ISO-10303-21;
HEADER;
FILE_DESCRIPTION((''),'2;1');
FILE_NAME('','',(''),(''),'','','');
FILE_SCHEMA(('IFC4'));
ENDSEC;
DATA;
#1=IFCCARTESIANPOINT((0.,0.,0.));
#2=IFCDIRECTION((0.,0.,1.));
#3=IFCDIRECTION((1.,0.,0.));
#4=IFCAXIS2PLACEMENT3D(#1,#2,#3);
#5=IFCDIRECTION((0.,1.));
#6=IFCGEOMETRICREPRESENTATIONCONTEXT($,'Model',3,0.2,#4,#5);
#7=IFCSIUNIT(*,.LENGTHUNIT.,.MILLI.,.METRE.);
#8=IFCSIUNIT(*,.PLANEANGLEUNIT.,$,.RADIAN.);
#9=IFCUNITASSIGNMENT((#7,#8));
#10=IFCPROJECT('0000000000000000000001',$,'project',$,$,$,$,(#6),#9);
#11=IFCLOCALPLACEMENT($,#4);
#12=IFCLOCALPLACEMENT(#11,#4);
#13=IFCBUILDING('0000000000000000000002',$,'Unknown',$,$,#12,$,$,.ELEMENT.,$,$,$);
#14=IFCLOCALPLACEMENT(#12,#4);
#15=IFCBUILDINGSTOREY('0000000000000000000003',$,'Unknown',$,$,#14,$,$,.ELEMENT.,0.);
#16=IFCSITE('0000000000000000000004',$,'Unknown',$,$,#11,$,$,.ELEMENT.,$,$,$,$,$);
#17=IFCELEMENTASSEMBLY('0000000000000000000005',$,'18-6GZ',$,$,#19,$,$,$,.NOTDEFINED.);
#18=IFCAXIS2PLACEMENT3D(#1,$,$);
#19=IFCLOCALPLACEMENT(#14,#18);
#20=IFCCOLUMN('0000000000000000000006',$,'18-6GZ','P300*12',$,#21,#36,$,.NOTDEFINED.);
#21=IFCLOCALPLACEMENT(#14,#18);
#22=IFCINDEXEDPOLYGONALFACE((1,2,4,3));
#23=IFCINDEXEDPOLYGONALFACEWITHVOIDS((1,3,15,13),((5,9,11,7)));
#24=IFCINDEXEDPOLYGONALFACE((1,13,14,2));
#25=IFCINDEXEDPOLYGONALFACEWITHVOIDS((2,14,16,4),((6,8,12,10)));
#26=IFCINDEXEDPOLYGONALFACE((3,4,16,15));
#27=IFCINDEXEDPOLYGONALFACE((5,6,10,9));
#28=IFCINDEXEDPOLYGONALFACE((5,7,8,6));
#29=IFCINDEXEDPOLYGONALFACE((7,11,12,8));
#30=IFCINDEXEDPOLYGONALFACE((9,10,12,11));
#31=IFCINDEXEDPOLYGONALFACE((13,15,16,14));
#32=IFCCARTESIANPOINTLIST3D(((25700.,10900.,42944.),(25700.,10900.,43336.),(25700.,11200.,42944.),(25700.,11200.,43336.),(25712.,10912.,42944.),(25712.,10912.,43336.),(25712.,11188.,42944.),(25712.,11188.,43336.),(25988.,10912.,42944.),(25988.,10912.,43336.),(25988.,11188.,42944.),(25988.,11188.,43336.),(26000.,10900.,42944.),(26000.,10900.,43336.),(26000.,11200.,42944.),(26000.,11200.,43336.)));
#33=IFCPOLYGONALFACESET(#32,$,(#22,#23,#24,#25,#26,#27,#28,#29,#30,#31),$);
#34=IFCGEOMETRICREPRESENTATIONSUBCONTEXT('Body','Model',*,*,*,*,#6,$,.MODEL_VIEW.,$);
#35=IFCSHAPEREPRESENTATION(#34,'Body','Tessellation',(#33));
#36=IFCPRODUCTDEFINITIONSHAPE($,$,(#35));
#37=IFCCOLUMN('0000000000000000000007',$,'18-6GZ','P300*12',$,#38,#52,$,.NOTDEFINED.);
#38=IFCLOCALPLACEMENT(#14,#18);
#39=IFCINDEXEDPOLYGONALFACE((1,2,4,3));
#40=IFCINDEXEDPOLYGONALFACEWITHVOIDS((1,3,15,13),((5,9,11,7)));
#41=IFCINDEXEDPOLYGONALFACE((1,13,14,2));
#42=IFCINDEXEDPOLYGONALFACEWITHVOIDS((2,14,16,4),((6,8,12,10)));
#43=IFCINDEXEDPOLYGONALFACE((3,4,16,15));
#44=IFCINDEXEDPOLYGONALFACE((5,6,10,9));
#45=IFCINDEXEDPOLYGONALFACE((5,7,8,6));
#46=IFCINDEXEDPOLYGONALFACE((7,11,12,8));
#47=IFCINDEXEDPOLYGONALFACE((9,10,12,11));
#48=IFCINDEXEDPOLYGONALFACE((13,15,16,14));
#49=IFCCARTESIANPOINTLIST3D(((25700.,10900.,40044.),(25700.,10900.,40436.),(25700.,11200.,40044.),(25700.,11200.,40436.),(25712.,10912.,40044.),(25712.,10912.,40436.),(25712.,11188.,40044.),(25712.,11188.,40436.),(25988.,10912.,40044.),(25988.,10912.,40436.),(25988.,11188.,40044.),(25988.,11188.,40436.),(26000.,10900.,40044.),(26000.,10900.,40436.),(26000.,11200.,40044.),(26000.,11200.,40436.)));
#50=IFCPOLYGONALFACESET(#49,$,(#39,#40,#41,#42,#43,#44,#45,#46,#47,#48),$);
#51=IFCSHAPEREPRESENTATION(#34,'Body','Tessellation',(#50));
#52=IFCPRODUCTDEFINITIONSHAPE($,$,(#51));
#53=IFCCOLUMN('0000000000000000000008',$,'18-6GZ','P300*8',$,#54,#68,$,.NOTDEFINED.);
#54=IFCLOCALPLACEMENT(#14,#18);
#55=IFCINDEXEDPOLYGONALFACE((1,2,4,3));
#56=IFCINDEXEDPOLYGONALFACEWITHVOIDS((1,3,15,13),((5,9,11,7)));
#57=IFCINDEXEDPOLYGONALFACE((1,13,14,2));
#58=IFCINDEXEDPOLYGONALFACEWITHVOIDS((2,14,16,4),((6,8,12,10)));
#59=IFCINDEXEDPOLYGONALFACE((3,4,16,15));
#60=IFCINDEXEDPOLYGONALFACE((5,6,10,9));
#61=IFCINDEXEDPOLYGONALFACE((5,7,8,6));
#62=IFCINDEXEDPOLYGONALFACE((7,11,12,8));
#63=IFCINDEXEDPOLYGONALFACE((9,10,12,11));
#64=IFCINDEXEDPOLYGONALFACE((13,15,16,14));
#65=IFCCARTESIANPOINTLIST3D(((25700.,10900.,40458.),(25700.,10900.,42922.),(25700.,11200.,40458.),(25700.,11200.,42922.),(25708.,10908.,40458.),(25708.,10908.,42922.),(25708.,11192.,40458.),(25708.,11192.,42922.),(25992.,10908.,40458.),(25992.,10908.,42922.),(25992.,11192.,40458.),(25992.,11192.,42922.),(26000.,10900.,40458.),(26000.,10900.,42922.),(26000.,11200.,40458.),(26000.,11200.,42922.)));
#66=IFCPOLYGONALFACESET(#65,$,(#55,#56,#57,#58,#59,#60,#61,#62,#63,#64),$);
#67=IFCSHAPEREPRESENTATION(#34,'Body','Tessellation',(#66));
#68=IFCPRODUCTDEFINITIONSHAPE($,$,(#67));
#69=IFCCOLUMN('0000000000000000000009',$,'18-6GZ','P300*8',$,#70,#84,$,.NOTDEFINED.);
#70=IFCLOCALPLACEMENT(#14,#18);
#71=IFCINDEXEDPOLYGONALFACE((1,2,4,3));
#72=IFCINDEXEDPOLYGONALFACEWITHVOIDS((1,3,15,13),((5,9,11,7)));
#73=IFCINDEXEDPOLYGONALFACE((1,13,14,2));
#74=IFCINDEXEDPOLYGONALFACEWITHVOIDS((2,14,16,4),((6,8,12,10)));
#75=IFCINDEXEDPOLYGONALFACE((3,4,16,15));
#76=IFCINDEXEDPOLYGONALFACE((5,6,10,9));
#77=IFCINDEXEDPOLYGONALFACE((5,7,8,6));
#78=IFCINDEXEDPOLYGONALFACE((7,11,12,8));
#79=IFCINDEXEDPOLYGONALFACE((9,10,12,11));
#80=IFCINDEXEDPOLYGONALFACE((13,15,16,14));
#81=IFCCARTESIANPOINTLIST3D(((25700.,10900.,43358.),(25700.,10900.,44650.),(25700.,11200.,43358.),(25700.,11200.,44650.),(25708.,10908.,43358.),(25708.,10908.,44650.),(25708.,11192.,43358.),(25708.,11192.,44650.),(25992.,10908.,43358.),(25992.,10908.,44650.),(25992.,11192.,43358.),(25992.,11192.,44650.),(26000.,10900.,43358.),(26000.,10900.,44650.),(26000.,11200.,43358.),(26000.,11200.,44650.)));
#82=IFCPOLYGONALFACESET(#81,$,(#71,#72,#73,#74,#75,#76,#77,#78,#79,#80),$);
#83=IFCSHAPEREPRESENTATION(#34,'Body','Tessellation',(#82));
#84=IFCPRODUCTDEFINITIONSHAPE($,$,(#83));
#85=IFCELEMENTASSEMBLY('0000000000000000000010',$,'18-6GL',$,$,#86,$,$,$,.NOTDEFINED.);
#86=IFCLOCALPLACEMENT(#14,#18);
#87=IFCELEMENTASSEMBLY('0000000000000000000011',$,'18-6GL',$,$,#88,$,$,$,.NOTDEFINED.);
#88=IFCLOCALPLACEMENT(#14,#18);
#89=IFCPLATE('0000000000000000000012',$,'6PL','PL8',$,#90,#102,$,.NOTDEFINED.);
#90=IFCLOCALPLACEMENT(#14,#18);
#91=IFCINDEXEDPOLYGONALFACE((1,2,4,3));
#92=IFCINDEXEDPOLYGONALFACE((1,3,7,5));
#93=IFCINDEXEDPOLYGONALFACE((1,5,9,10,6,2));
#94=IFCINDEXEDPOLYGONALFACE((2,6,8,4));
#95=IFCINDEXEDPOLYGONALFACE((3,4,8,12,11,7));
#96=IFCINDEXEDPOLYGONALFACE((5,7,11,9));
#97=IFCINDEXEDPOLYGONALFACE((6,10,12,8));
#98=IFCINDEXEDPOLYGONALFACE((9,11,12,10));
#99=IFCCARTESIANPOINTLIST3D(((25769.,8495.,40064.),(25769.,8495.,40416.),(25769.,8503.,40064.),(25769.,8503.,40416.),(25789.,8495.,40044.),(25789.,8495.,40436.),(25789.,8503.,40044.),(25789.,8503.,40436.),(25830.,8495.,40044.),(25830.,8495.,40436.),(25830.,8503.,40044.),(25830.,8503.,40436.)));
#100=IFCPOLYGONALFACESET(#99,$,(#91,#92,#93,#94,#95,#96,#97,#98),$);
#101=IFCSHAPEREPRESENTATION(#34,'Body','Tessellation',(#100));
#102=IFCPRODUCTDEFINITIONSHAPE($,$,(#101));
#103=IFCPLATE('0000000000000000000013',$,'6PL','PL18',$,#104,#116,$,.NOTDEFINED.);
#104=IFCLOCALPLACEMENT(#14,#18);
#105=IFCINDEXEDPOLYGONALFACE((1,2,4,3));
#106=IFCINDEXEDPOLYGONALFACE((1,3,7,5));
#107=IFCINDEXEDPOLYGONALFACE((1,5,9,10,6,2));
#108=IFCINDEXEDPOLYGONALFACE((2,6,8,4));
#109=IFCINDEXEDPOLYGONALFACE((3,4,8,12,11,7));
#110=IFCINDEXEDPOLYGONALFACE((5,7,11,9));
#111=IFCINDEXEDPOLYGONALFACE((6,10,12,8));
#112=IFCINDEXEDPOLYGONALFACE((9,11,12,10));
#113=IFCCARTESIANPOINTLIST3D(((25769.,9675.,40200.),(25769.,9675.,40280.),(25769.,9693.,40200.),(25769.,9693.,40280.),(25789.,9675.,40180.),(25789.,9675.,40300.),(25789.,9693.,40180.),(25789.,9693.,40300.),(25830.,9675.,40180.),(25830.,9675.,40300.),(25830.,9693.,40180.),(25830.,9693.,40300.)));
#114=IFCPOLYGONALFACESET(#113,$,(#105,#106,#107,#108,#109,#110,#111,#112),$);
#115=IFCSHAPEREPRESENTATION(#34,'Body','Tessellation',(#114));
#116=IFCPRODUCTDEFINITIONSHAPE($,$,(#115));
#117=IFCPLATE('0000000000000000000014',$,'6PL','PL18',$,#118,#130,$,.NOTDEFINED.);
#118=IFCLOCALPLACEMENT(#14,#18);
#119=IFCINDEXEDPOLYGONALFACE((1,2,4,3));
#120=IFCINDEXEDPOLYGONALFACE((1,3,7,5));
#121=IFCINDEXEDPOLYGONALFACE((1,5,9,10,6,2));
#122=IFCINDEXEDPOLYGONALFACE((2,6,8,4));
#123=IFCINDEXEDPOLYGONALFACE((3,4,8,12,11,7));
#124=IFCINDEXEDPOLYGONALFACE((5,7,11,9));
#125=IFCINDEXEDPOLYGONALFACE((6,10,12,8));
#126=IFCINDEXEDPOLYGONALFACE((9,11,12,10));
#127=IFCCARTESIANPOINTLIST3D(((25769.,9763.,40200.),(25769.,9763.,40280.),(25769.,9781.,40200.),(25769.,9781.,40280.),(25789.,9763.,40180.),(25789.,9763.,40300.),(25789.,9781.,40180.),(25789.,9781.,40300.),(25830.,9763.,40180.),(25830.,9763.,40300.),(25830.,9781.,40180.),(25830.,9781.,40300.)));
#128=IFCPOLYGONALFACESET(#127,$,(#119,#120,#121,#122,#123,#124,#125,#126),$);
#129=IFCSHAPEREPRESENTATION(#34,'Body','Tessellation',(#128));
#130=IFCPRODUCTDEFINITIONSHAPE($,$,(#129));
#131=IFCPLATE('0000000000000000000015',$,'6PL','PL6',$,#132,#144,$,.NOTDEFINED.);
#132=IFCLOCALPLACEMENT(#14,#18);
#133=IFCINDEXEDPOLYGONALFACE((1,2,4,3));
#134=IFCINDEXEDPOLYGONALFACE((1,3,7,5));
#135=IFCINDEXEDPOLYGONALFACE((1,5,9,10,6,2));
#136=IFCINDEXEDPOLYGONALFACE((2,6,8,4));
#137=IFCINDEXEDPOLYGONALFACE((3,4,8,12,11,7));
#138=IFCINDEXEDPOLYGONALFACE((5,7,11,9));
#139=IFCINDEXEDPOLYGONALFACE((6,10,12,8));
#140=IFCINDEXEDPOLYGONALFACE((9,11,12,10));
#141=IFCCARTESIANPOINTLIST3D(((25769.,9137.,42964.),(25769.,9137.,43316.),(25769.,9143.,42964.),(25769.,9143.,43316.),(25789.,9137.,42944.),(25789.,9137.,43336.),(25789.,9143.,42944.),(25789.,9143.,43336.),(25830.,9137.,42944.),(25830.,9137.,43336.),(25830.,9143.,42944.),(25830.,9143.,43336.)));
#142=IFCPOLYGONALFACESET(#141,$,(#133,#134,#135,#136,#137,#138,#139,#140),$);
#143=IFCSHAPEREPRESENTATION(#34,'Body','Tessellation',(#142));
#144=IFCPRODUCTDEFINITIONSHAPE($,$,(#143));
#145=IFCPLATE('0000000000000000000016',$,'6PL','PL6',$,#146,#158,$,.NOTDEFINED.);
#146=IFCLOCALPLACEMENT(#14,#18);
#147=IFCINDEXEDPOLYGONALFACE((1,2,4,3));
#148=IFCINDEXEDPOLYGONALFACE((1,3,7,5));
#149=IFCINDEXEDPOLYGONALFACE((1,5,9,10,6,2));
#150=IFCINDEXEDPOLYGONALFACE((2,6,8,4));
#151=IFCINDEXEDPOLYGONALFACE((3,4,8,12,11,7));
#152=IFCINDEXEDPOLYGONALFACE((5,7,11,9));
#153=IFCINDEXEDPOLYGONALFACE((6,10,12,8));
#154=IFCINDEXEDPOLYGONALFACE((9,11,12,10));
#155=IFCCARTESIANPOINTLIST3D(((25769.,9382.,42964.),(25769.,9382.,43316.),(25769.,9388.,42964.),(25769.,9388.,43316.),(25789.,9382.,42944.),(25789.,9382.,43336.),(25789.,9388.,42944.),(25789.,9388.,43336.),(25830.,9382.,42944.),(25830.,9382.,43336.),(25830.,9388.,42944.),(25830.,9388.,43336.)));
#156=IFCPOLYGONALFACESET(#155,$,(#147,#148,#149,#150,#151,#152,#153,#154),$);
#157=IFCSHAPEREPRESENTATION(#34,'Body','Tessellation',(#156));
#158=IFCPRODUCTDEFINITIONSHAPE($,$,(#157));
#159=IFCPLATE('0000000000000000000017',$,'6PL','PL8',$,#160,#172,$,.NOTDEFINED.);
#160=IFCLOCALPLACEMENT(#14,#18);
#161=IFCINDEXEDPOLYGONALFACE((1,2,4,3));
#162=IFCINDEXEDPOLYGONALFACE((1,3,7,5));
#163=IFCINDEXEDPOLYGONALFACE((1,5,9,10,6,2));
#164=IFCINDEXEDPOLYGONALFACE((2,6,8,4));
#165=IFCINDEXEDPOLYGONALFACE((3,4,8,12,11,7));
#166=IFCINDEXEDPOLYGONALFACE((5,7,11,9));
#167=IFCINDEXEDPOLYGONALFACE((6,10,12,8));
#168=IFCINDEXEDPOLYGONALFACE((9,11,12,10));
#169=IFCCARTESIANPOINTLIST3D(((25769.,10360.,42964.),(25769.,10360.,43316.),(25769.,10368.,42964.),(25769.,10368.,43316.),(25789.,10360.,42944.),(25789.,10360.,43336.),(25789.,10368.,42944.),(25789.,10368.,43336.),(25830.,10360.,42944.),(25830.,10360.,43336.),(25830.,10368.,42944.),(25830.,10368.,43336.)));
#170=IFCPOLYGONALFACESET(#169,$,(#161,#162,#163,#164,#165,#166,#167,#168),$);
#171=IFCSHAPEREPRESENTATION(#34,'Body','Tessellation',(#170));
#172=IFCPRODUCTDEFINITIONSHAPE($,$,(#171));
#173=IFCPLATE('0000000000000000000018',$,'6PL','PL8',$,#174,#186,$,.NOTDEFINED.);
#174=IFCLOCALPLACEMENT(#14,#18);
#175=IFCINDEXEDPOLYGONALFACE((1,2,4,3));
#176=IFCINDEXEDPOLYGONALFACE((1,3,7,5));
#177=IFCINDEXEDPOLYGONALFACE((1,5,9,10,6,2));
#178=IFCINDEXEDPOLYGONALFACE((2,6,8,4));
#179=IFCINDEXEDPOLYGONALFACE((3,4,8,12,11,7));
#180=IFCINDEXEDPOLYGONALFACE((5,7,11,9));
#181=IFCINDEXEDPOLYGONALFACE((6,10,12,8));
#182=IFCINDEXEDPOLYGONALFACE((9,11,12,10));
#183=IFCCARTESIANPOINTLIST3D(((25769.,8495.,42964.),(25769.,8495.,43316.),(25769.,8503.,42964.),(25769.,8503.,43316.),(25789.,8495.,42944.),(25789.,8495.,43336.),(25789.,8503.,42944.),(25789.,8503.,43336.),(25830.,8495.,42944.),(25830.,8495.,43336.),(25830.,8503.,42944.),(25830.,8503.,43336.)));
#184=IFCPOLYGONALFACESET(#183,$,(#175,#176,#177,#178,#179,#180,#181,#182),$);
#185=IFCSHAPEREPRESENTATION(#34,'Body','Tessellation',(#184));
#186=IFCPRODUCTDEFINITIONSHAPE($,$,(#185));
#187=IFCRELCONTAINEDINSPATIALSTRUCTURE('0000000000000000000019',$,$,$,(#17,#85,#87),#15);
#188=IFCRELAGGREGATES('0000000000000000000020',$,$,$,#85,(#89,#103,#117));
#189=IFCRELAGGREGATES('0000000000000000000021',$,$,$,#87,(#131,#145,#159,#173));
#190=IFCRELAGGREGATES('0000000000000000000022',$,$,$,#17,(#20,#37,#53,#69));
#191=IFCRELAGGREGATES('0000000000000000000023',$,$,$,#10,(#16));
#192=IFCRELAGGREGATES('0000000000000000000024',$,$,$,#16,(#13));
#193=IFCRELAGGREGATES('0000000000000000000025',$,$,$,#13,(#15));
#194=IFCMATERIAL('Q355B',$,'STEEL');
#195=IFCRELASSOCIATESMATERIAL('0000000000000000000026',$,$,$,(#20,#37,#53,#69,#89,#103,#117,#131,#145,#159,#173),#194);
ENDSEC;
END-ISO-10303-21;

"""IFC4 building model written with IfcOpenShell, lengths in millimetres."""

from ifc_helpers import new_model, si_unit, direction, frame, origin_with_axes, place, context, subcontext, project, spatial, line, indexed_curve, outline, extrude, material, element, aggregate, save


model = new_model("IFC4")

# Units and contexts
model_context = context("Model", 3, precision=0.2, world=origin_with_axes(), true_north=direction((0.0, 1.0)))
body_context = subcontext(model_context, "Body", "Model", "MODEL_VIEW")
ifc_project = project(units=[si_unit("LENGTHUNIT", "METRE", prefix="MILLI"), si_unit("PLANEANGLEUNIT", "RADIAN")], contexts=[model_context])

# Site, building, storey
site_placement = place(None, origin_with_axes())
site = spatial("IfcSite", under=ifc_project, at=site_placement, Name="Unknown", CompositionType="ELEMENT")
building_placement = place(site_placement, origin_with_axes())
building = spatial("IfcBuilding", under=site, at=building_placement, Name="Unknown", CompositionType="ELEMENT")
storey_placement = place(building_placement, origin_with_axes())
storey = spatial("IfcBuildingStorey", under=building, at=storey_placement, Name="Unknown", CompositionType="ELEMENT", Elevation=0.0)

# Element assembly, columns
assembly_1_placement = place(storey_placement, frame((25850.0, 11050.0, 35950.0), z_axis=(-1.0, 0.0, 0.0), x_axis=(0.0, 0.0, 1.0)))
assembly_1 = element("IfcElementAssembly", 1, at=assembly_1_placement, inside=storey, Name="18-6GZ", PredefinedType="NOTDEFINED")
ifc_material_1 = material(Name="Q355B", Category="STEEL")
column_1_placement = place(assembly_1_placement, frame((6994.0, 0.0, 0.0), z_axis=(0.0, 0.0, 1.0), x_axis=(1.0, 0.0, 0.0)))
column_1 = element("IfcColumn", 2, at=column_1_placement, material=ifc_material_1, Name="18-6GZ", Description="P300*12", PredefinedType="NOTDEFINED", context=body_context, shape_type="SolidModel", body=[
    extrude(outline(indexed_curve([(-150.0, -150.0), (150.0, -150.0), (150.0, 150.0), (-150.0, 150.0)], segments=[line(1, 2, 3, 4, 1)]), holes=[indexed_curve([(-138.0, -138.0), (-138.0, 138.0), (138.0, 138.0), (138.0, -138.0)], segments=[line(1, 2, 3, 4, 1)])]), frame((0.0, 0.0, 0.0), z_axis=(-1.0, 0.0, 0.0), x_axis=(0.0, 0.0, 1.0)), (0.0, 0.0, -1.0), 392.0),
])
column_2_placement = place(assembly_1_placement, frame((4094.0, 0.0, 0.0), z_axis=(0.0, 0.0, 1.0), x_axis=(1.0, 0.0, 0.0)))
column_2 = element("IfcColumn", 3, at=column_2_placement, material=ifc_material_1, Name="18-6GZ", Description="P300*12", PredefinedType="NOTDEFINED", context=body_context, shape_type="SolidModel", body=[
    extrude(outline(indexed_curve([(-150.0, -150.0), (150.0, -150.0), (150.0, 150.0), (-150.0, 150.0)], segments=[line(1, 2, 3, 4, 1)]), holes=[indexed_curve([(-138.0, -138.0), (-138.0, 138.0), (138.0, 138.0), (138.0, -138.0)], segments=[line(1, 2, 3, 4, 1)])]), frame((0.0, 0.0, 0.0), z_axis=(-1.0, 0.0, 0.0), x_axis=(0.0, 0.0, 1.0)), (0.0, 0.0, -1.0), 392.0),
])
column_3_placement = place(assembly_1_placement, frame((4508.0, 0.0, 0.0), z_axis=(0.0, 0.0, 1.0), x_axis=(1.0, 0.0, 0.0)))
column_3 = element("IfcColumn", 4, at=column_3_placement, material=ifc_material_1, Name="18-6GZ", Description="P300*8", PredefinedType="NOTDEFINED", context=body_context, shape_type="SolidModel", body=[
    extrude(outline(indexed_curve([(-150.0, -150.0), (150.0, -150.0), (150.0, 150.0), (-150.0, 150.0)], segments=[line(1, 2, 3, 4, 1)]), holes=[indexed_curve([(-142.0, -142.0), (-142.0, 142.0), (142.0, 142.0), (142.0, -142.0)], segments=[line(1, 2, 3, 4, 1)])]), frame((0.0, 0.0, 0.0), z_axis=(-1.0, 0.0, 0.0), x_axis=(0.0, 0.0, 1.0)), (0.0, 0.0, -1.0), 2464.0),
])
column_4_placement = place(assembly_1_placement, frame((7408.0, 0.0, 0.0), z_axis=(0.0, 0.0, 1.0), x_axis=(1.0, 0.0, 0.0)))
column_4 = element("IfcColumn", 5, at=column_4_placement, material=ifc_material_1, Name="18-6GZ", Description="P300*8", PredefinedType="NOTDEFINED", context=body_context, shape_type="SolidModel", body=[
    extrude(outline(indexed_curve([(-150.0, -150.0), (150.0, -150.0), (150.0, 150.0), (-150.0, 150.0)], segments=[line(1, 2, 3, 4, 1)]), holes=[indexed_curve([(-142.0, -142.0), (-142.0, 142.0), (142.0, 142.0), (142.0, -142.0)], segments=[line(1, 2, 3, 4, 1)])]), frame((0.0, 0.0, 0.0), z_axis=(-1.0, 0.0, 0.0), x_axis=(0.0, 0.0, 1.0)), (0.0, 0.0, -1.0), 1292.0),
])

# Element assemblies
assembly_2_placement = place(storey_placement, frame((25765.0, 10900.0, 40240.0), z_axis=(-1.0, 0.0, 0.0), x_axis=(0.0, -1.0, 0.0)))
assembly_2 = element("IfcElementAssembly", 6, at=assembly_2_placement, inside=storey, Name="18-6GL", PredefinedType="NOTDEFINED")
assembly_3_placement = place(storey_placement, frame((25765.0, 10900.0, 43140.0), z_axis=(-1.0, 0.0, 0.0), x_axis=(0.0, -1.0, 0.0)))
assembly_3 = element("IfcElementAssembly", 7, at=assembly_3_placement, inside=storey, Name="18-6GL", PredefinedType="NOTDEFINED")

# Plates
plate_1_placement = place(assembly_2_placement, frame((2401.0, -196.0, -65.0), z_axis=(-1.0, 0.0, 0.0), x_axis=(0.0, 0.0, 1.0)))
plate_1 = element("IfcPlate", 8, at=plate_1_placement, material=ifc_material_1, Name="6PL", Description="PL8", PredefinedType="NOTDEFINED", context=body_context, shape_type="SolidModel", body=[
    extrude(outline(indexed_curve([(0.0, 0.0), (41.0, 0.0), (61.0, 20.0), (61.0, 372.0), (41.0, 392.0), (0.0, 392.0)], segments=[line(1, 2, 3, 4, 5, 6, 1)])), frame((0.0, 0.0, 4.0), z_axis=(0.0, 0.0, 1.0), x_axis=(1.0, 0.0, 0.0)), (0.0, 0.0, -1.0), 8.0),
])
plate_2_placement = place(assembly_2_placement, frame((1216.0, -60.0, -65.0), z_axis=(-1.0, 0.0, 0.0), x_axis=(0.0, 0.0, 1.0)))
plate_2 = element("IfcPlate", 9, at=plate_2_placement, material=ifc_material_1, Name="6PL", Description="PL18", PredefinedType="NOTDEFINED", context=body_context, shape_type="SolidModel", body=[
    extrude(outline(indexed_curve([(0.0, 0.0), (41.0, 0.0), (61.0, 20.0), (61.0, 100.0), (41.0, 120.0), (0.0, 120.0)], segments=[line(1, 2, 3, 4, 5, 6, 1)])), frame((0.0, 0.0, 9.0), z_axis=(0.0, 0.0, 1.0), x_axis=(1.0, 0.0, 0.0)), (0.0, 0.0, -1.0), 18.0),
])
plate_3_placement = place(assembly_2_placement, frame((1128.0, -60.0, -65.0), z_axis=(-1.0, 0.0, 0.0), x_axis=(0.0, 0.0, 1.0)))
plate_3 = element("IfcPlate", 10, at=plate_3_placement, material=ifc_material_1, Name="6PL", Description="PL18", PredefinedType="NOTDEFINED", context=body_context, shape_type="SolidModel", body=[
    extrude(outline(indexed_curve([(0.0, 0.0), (41.0, 0.0), (61.0, 20.0), (61.0, 100.0), (41.0, 120.0), (0.0, 120.0)], segments=[line(1, 2, 3, 4, 5, 6, 1)])), frame((0.0, 0.0, 9.0), z_axis=(0.0, 0.0, 1.0), x_axis=(1.0, 0.0, 0.0)), (0.0, 0.0, -1.0), 18.0),
])
aggregate(assembly_2, [plate_1, plate_2, plate_3])
plate_4_placement = place(assembly_3_placement, frame((1760.0, -196.0, -65.0), z_axis=(-1.0, 0.0, 0.0), x_axis=(0.0, 0.0, 1.0)))
plate_4 = element("IfcPlate", 11, at=plate_4_placement, material=ifc_material_1, Name="6PL", Description="PL6", PredefinedType="NOTDEFINED", context=body_context, shape_type="SolidModel", body=[
    extrude(outline(indexed_curve([(0.0, 0.0), (41.0, 0.0), (61.0, 20.0), (61.0, 372.0), (41.0, 392.0), (0.0, 392.0)], segments=[line(1, 2, 3, 4, 5, 6, 1)])), frame((0.0, 0.0, 3.0), z_axis=(0.0, 0.0, 1.0), x_axis=(1.0, 0.0, 0.0)), (0.0, 0.0, -1.0), 6.0),
])
plate_5_placement = place(assembly_3_placement, frame((1515.0, -196.0, -65.0), z_axis=(-1.0, 0.0, 0.0), x_axis=(0.0, 0.0, 1.0)))
plate_5 = element("IfcPlate", 12, at=plate_5_placement, material=ifc_material_1, Name="6PL", Description="PL6", PredefinedType="NOTDEFINED", context=body_context, shape_type="SolidModel", body=[
    extrude(outline(indexed_curve([(0.0, 0.0), (41.0, 0.0), (61.0, 20.0), (61.0, 372.0), (41.0, 392.0), (0.0, 392.0)], segments=[line(1, 2, 3, 4, 5, 6, 1)])), frame((0.0, 0.0, 3.0), z_axis=(0.0, 0.0, 1.0), x_axis=(1.0, 0.0, 0.0)), (0.0, 0.0, -1.0), 6.0),
])
plate_6_placement = place(assembly_3_placement, frame((536.0, -196.0, -65.0), z_axis=(-1.0, 0.0, 0.0), x_axis=(0.0, 0.0, 1.0)))
plate_6 = element("IfcPlate", 13, at=plate_6_placement, material=ifc_material_1, Name="6PL", Description="PL8", PredefinedType="NOTDEFINED", context=body_context, shape_type="SolidModel", body=[
    extrude(outline(indexed_curve([(0.0, 0.0), (41.0, 0.0), (61.0, 20.0), (61.0, 372.0), (41.0, 392.0), (0.0, 392.0)], segments=[line(1, 2, 3, 4, 5, 6, 1)])), frame((0.0, 0.0, 4.0), z_axis=(0.0, 0.0, 1.0), x_axis=(1.0, 0.0, 0.0)), (0.0, 0.0, -1.0), 8.0),
])
plate_7_placement = place(assembly_3_placement, frame((2401.0, -196.0, -65.0), z_axis=(-1.0, 0.0, 0.0), x_axis=(0.0, 0.0, 1.0)))
plate_7 = element("IfcPlate", 14, at=plate_7_placement, material=ifc_material_1, Name="6PL", Description="PL8", PredefinedType="NOTDEFINED", context=body_context, shape_type="SolidModel", body=[
    extrude(outline(indexed_curve([(0.0, 0.0), (41.0, 0.0), (61.0, 20.0), (61.0, 372.0), (41.0, 392.0), (0.0, 392.0)], segments=[line(1, 2, 3, 4, 5, 6, 1)])), frame((0.0, 0.0, 4.0), z_axis=(0.0, 0.0, 1.0), x_axis=(1.0, 0.0, 0.0)), (0.0, 0.0, -1.0), 8.0),
])
aggregate(assembly_3, [plate_4, plate_5, plate_6, plate_7])

aggregate(assembly_1, [column_1, column_2, column_3, column_4])

save(model, "model.ifc")
